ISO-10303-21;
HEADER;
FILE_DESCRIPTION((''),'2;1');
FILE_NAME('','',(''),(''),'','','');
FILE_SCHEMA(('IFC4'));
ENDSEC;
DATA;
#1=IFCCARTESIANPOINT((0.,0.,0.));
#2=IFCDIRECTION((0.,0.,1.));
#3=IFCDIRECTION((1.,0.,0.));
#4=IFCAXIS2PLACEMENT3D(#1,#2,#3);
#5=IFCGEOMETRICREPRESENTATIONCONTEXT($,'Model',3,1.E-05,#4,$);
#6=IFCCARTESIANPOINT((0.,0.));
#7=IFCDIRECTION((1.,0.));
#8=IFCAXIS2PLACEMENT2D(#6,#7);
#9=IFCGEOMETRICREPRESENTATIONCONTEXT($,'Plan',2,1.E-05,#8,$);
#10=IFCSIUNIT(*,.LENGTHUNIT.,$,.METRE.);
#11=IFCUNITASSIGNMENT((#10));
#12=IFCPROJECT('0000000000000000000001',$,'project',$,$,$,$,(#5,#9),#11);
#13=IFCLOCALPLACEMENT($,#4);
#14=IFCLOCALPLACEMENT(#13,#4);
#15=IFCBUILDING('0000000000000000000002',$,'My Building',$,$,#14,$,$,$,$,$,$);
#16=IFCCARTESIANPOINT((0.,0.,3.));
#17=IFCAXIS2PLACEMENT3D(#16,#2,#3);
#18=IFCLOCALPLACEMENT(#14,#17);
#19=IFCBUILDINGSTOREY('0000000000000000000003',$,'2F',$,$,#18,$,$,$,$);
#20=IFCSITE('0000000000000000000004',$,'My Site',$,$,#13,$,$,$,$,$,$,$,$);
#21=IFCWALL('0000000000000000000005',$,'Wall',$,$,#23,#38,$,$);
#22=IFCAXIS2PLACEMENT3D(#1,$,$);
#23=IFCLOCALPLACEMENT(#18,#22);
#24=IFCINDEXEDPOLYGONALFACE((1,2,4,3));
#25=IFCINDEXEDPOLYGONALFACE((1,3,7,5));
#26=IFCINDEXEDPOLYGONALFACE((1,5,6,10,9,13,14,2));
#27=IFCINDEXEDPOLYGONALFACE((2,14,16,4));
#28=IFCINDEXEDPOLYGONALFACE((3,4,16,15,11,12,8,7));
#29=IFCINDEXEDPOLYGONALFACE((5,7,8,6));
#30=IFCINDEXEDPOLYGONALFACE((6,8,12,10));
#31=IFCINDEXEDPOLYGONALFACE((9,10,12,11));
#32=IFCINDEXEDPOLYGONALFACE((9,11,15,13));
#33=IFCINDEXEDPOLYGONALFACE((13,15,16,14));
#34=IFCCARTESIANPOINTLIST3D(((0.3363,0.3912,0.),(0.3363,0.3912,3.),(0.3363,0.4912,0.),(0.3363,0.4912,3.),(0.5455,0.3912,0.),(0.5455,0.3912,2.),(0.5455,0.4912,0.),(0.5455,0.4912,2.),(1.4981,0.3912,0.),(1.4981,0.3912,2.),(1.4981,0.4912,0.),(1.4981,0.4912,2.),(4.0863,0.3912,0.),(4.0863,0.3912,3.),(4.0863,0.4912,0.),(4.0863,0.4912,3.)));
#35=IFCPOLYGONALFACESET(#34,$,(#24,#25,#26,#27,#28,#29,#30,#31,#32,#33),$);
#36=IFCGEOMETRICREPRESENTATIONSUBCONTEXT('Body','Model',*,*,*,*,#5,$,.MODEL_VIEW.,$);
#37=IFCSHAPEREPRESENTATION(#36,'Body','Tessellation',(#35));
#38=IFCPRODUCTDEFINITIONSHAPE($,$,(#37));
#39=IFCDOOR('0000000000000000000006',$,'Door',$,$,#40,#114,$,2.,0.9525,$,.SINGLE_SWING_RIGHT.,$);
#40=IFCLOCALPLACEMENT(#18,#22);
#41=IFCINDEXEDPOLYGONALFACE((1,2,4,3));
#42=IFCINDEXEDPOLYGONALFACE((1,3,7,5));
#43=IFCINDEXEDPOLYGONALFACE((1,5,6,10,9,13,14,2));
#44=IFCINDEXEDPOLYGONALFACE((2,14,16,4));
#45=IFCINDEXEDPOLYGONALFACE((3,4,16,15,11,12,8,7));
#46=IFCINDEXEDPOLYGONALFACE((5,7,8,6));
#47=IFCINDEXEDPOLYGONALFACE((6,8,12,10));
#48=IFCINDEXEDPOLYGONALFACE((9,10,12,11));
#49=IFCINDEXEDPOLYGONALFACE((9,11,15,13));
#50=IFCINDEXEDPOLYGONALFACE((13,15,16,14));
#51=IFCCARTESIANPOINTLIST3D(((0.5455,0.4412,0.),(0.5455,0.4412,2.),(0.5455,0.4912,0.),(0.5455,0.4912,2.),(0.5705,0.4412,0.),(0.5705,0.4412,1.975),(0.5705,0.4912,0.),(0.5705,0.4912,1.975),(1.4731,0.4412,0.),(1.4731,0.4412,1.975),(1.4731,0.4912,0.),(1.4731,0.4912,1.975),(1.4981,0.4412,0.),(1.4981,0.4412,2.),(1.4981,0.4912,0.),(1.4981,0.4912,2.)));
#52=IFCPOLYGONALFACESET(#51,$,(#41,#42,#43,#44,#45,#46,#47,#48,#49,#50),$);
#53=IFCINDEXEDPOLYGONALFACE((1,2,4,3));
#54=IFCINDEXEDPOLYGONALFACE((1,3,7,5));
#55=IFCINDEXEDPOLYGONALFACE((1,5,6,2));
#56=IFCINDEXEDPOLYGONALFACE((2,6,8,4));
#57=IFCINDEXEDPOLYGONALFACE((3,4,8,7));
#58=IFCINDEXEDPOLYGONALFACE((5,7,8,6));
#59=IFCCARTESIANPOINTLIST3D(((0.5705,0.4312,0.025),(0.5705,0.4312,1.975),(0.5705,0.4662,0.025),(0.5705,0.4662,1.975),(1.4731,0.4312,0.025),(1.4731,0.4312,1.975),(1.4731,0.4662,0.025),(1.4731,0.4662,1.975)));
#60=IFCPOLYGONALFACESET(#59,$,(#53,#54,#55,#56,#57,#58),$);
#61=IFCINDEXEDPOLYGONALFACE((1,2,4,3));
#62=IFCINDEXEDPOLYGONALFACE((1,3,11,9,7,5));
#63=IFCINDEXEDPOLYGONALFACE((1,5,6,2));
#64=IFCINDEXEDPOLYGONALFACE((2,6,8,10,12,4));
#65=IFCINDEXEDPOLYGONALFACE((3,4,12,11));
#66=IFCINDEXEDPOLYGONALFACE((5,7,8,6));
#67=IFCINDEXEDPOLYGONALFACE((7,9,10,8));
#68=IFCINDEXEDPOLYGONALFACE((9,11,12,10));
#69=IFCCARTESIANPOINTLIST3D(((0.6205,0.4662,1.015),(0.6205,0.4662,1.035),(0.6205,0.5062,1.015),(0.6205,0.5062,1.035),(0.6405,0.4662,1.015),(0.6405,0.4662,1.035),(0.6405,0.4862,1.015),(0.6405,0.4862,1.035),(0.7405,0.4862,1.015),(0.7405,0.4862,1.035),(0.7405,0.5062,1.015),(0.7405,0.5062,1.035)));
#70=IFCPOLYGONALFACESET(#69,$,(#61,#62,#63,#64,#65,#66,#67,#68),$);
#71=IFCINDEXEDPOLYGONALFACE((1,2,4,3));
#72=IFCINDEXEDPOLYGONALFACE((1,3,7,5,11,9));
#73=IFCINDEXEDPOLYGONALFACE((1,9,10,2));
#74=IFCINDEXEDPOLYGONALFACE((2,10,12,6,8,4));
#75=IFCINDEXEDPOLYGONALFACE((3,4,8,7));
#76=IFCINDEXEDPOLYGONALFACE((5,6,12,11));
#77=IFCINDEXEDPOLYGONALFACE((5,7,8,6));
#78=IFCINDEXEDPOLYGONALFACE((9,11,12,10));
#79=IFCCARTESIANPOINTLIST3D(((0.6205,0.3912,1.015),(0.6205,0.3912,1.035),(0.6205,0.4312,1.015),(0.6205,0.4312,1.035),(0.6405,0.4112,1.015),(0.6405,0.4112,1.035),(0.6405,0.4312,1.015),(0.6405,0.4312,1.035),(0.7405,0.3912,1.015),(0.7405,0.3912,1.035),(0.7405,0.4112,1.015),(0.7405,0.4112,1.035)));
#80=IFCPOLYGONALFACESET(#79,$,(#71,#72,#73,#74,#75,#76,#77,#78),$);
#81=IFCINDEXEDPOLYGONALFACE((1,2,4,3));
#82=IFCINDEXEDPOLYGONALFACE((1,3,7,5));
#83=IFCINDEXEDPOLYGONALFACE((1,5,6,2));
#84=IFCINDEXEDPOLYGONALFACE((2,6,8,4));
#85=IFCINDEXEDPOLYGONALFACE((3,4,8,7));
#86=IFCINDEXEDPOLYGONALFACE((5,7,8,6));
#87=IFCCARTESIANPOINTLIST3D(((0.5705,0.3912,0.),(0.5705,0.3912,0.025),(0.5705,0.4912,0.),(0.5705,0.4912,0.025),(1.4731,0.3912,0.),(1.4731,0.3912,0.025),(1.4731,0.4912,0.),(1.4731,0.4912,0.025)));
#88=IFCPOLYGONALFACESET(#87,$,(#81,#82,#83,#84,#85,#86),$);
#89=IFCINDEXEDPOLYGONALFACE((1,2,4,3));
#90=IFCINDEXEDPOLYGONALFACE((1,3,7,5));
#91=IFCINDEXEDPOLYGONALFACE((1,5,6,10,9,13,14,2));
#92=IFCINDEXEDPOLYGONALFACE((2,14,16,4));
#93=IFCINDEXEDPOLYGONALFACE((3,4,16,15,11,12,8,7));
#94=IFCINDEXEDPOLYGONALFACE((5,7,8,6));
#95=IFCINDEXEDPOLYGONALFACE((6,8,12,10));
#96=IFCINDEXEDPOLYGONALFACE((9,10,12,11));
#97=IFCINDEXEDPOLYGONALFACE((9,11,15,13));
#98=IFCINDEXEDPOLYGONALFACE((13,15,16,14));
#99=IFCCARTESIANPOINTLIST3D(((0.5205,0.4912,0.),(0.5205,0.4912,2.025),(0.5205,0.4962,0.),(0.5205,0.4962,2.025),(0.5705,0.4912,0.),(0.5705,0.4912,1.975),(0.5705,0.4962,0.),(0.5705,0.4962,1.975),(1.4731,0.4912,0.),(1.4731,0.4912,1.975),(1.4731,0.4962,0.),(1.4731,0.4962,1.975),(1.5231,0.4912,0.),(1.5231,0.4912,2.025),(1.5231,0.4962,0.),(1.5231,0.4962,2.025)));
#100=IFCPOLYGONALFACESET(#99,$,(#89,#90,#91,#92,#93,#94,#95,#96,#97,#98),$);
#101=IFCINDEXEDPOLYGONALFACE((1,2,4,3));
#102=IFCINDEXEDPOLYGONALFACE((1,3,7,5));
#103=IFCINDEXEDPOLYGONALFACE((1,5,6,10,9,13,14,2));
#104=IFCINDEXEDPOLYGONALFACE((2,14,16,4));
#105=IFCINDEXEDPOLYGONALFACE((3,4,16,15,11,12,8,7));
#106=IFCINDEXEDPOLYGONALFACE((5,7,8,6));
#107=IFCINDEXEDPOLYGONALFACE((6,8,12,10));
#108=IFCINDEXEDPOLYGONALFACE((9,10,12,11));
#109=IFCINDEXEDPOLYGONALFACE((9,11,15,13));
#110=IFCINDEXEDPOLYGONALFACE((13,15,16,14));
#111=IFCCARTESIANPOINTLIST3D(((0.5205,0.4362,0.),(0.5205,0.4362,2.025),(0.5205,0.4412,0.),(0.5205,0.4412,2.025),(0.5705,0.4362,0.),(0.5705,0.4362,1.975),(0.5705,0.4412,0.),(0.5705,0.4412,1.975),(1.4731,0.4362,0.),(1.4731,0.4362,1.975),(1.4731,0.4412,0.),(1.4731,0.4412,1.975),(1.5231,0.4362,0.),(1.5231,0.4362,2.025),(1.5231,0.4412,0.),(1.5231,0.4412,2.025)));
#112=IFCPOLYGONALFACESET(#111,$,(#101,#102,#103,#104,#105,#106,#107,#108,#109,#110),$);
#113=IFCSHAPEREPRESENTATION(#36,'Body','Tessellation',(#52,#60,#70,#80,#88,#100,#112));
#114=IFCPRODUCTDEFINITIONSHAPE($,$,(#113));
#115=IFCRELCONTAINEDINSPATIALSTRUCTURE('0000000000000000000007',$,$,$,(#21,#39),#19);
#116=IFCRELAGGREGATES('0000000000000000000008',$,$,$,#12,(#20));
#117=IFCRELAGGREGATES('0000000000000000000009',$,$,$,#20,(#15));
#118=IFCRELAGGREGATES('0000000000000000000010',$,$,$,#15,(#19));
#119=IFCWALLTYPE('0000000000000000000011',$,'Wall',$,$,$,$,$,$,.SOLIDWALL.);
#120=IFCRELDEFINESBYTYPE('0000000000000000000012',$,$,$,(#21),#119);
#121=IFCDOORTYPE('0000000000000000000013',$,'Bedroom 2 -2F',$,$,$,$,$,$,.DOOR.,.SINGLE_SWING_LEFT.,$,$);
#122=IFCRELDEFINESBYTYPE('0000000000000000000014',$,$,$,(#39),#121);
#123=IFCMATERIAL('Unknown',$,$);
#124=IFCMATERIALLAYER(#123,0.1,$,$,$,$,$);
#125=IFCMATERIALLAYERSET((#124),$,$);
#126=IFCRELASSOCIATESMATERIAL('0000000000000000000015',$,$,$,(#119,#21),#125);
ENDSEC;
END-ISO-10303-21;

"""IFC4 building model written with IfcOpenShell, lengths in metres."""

from ifc_helpers import new_model, entity, si_unit, frame, origin_with_axes, origin_2d_with_axis, place, context, subcontext, project, spatial, line, indexed_curve, outline, extrude, shape, source, transform, mapped, material, layer, layer_set, layer_usage, type_object, type_shapes, element, fill, save


model = new_model("IFC4")

# Units and contexts
model_context = context("Model", 3, precision=1e-05, world=origin_with_axes())
plan_context = context("Plan", 2, precision=1e-05, world=origin_2d_with_axis())
body_context_1 = subcontext(model_context, "Body", "Model", "MODEL_VIEW")
body_context_2 = subcontext(plan_context, "Body", "Plan", "PLAN_VIEW")
ifc_project = project(units=[si_unit("LENGTHUNIT", "METRE")], contexts=[model_context, plan_context])

# Site, building, storey
site_placement = place(None, origin_with_axes())
site = spatial("IfcSite", under=ifc_project, at=site_placement, Name="My Site")
building_placement = place(site_placement, origin_with_axes())
building = spatial("IfcBuilding", under=site, at=building_placement, Name="My Building")
storey_placement = place(building_placement, frame((0.0, 0.0, 3.0), z_axis=(0.0, 0.0, 1.0), x_axis=(1.0, 0.0, 0.0)))
storey = spatial("IfcBuildingStorey", under=building, at=storey_placement, Name="2F")

# Shared definitions
ifc_material = material(Name="Unknown")

# Shared definitions
ifc_layer_1 = layer(ifc_material, 0.1)
ifc_layer_set_1 = layer_set([ifc_layer_1])
wall_type = type_object("IfcWallType", Name="Wall", PredefinedType="SOLIDWALL", material=ifc_layer_set_1)

# Shared definitions
shared_shape_1 = source(origin_with_axes(), body_context_1, "Body", "SweptSolid", [
    extrude(outline(indexed_curve([(0.0, 0.0), (0.9525, 0.0), (0.9525, 2.0), (0.0, 2.0)], segments=[line(1, 2, 3, 4, 1)])), frame((0.0, -0.6, 0.0), z_axis=(0.0, -1.0, 0.0), x_axis=(1.0, 0.0, 0.0)), (0.0, 0.0, -1.0), 1.2),
])
door_type_1 = type_object("IfcDoorType", Name="Bedroom 2 -2F", OperationType="SINGLE_SWING_LEFT", PredefinedType="DOOR")
shared_shape_2 = source(origin_with_axes(), body_context_1, "Body", "SweptSolid", [
    extrude(outline(indexed_curve([(0.0, 0.0), (0.0, 2.0), (0.9525, 2.0), (0.9525, 0.0), (0.9275, 0.0), (0.9275, 1.975), (0.025, 1.975), (0.025, 0.0)], segments=[line(1, 2, 3, 4, 5, 6, 7, 8, 1)])), frame((0.0, 0.0, 0.0), z_axis=(0.0, -1.0, 0.0), x_axis=(1.0, 0.0, 0.0)), (0.0, 0.0, -1.0), 0.05),
    extrude(outline(indexed_curve([(0.0, 0.0), (0.9025, 0.0), (0.9025, 0.035), (0.0, 0.035)], segments=[line(1, 2, 3, 4, 1)])), frame((0.025, 0.025, 0.025), z_axis=(0.0, 0.0, 1.0), x_axis=(1.0, 0.0, 0.0)), (0.0, 0.0, 1.0), 1.95),
    extrude(outline(indexed_curve([(0.0, 0.0), (0.0, -0.04), (-0.12, -0.04), (-0.12, -0.02), (-0.02, -0.02), (-0.02, 0.0)], segments=[line(1, 2, 3, 4, 5, 6, 1)])), frame((0.8775, 0.025, 1.015), z_axis=(0.0, 0.0, 1.0), x_axis=(1.0, 0.0, 0.0)), (0.0, 0.0, 1.0), 0.02),
    extrude(outline(indexed_curve([(0.0, 0.0), (0.0, 0.04), (-0.12, 0.04), (-0.12, 0.02), (-0.02, 0.02), (-0.02, 0.0)], segments=[line(1, 2, 3, 4, 5, 6, 1)])), frame((0.8775, 0.06, 1.015), z_axis=(0.0, 0.0, 1.0), x_axis=(1.0, 0.0, 0.0)), (0.0, 0.0, 1.0), 0.02),
    extrude(outline(indexed_curve([(0.0, 0.0), (0.9025, 0.0), (0.9025, 0.1), (0.0, 0.1)], segments=[line(1, 2, 3, 4, 1)])), frame((0.025, 0.0, 0.0), z_axis=(0.0, 0.0, 1.0), x_axis=(1.0, 0.0, 0.0)), (0.0, 0.0, 1.0), 0.025),
    extrude(outline(indexed_curve([(0.0, 0.0), (0.0, 2.025), (1.0025, 2.025), (1.0025, 0.0), (0.9525, 0.0), (0.9525, 1.975), (0.05, 1.975), (0.05, 0.0)], segments=[line(1, 2, 3, 4, 5, 6, 7, 8, 1)])), frame((-0.025, -0.005, 0.0), z_axis=(0.0, -1.0, 0.0), x_axis=(1.0, 0.0, 0.0)), (0.0, 0.0, -1.0), 0.005),
    extrude(outline(indexed_curve([(0.0, 0.0), (0.0, 2.025), (1.0025, 2.025), (1.0025, 0.0), (0.9525, 0.0), (0.9525, 1.975), (0.05, 1.975), (0.05, 0.0)], segments=[line(1, 2, 3, 4, 5, 6, 7, 8, 1)])), frame((-0.025, 0.05, 0.0), z_axis=(0.0, -1.0, 0.0), x_axis=(1.0, 0.0, 0.0)), (0.0, 0.0, -1.0), 0.005),
])
shared_shape_3 = source(origin_with_axes(), body_context_2, "Body", "Curve2D", [
    entity("IfcIndexedPolyCurve", entity("IfcCartesianPointList2D", [[0.0, 0.0], [0.025, 0.0], [0.025, 0.05], [0.0, 0.05]]), [entity("IfcLineIndex", [1, 2, 3, 4, 1])]),
    entity("IfcIndexedPolyCurve", entity("IfcCartesianPointList2D", [[0.9525, 0.0], [0.9275, 0.0], [0.9275, 0.05], [0.9525, 0.05]]), [entity("IfcLineIndex", [1, 2, 3, 4, 1])]),
    entity("IfcIndexedPolyCurve", entity("IfcCartesianPointList2D", [[0.025, 0.05], [0.025, -0.8525], [0.06, -0.8525]])),
    entity("IfcTrimmedCurve", entity("IfcEllipse", entity("IfcAxis2Placement2D", entity("IfcCartesianPoint", [0.06, 0.05]), entity("IfcDirection", [1.0, 0.0])), 0.8675, 0.9025), [entity("IfcCartesianPoint", [0.06, -0.8525])], [entity("IfcCartesianPoint", [0.06, 0.9525])], True, "CARTESIAN"),
    entity("IfcIndexedPolyCurve", entity("IfcCartesianPointList2D", [[0.025, 0.05], [0.06, 0.05], [0.06, 0.9525], [0.025, 0.9525]]), [entity("IfcLineIndex", [1, 2, 3, 4, 1])]),
])
type_shapes(door_type_1, [shared_shape_2, shared_shape_3])

# Wall, opening, door
ifc_layer_usage_1 = layer_usage(ifc_layer_set_1, "AXIS2", "POSITIVE", 0.0)
wall_1_placement = place(storey_placement, frame((4.0863, 0.4912, 0.0), z_axis=(0.0, 0.0, 1.0), x_axis=(-1.0, 0.0, 0.0)))
wall_1 = element("IfcWall", 1, at=wall_1_placement, inside=storey, type_object=wall_type, material=ifc_layer_usage_1, Name="Wall", context=body_context_1, shape_type="SweptSolid", body=[
    extrude(outline(indexed_curve([(0.0, 0.0), (0.0, 0.1), (3.75, 0.1), (3.75, 0.0)], segments=[line(1, 2, 3, 4, 1)])), origin_with_axes(), (0.0, 0.0, 1.0), 3.0),
])
opening_1_placement = place(wall_1_placement, frame((2.5882, 0.0, 0.0), z_axis=(0.0, 0.0, 1.0), x_axis=(1.0, 0.0, 0.0)))
opening_1 = element("IfcOpeningElement", 2, at=opening_1_placement, cuts=wall_1, PredefinedType="OPENING", context=body_context_1, shape_type="MappedRepresentation", body=[
    mapped(shared_shape_1, transform((0.0, 0.0, 0.0), x_axis=(1.0, 0.0, 0.0), y_axis=(0.0, 1.0, 0.0), z_axis=(0.0, 0.0, 1.0), scale=1.0)),
])
door_1_placement = place(opening_1_placement, frame((0.0, 0.0, 0.0), z_axis=(0.0, 0.0, 1.0), x_axis=(1.0, 0.0, 0.0)))
door_1 = element("IfcDoor", 3, at=door_1_placement, inside=storey, type_object=door_type_1, Name="Door", OperationType="SINGLE_SWING_RIGHT", OverallHeight=2.0, OverallWidth=0.9525, shapes=[
    shape(body_context_1, "Body", "MappedRepresentation", [mapped(shared_shape_2, transform((0.0, 0.0, 0.0), x_axis=(1.0, 0.0, 0.0), y_axis=(0.0, 1.0, 0.0), z_axis=(0.0, 0.0, 1.0), scale=1.0))]),
    shape(body_context_2, "Body", "MappedRepresentation", [mapped(shared_shape_3, transform((0.0, 0.0, 0.0), x_axis=(1.0, 0.0, 0.0), y_axis=(0.0, 1.0, 0.0), z_axis=(0.0, 0.0, 1.0), scale=1.0))]),
])
fill(opening_1, door_1)

save(model, "model.ifc")
